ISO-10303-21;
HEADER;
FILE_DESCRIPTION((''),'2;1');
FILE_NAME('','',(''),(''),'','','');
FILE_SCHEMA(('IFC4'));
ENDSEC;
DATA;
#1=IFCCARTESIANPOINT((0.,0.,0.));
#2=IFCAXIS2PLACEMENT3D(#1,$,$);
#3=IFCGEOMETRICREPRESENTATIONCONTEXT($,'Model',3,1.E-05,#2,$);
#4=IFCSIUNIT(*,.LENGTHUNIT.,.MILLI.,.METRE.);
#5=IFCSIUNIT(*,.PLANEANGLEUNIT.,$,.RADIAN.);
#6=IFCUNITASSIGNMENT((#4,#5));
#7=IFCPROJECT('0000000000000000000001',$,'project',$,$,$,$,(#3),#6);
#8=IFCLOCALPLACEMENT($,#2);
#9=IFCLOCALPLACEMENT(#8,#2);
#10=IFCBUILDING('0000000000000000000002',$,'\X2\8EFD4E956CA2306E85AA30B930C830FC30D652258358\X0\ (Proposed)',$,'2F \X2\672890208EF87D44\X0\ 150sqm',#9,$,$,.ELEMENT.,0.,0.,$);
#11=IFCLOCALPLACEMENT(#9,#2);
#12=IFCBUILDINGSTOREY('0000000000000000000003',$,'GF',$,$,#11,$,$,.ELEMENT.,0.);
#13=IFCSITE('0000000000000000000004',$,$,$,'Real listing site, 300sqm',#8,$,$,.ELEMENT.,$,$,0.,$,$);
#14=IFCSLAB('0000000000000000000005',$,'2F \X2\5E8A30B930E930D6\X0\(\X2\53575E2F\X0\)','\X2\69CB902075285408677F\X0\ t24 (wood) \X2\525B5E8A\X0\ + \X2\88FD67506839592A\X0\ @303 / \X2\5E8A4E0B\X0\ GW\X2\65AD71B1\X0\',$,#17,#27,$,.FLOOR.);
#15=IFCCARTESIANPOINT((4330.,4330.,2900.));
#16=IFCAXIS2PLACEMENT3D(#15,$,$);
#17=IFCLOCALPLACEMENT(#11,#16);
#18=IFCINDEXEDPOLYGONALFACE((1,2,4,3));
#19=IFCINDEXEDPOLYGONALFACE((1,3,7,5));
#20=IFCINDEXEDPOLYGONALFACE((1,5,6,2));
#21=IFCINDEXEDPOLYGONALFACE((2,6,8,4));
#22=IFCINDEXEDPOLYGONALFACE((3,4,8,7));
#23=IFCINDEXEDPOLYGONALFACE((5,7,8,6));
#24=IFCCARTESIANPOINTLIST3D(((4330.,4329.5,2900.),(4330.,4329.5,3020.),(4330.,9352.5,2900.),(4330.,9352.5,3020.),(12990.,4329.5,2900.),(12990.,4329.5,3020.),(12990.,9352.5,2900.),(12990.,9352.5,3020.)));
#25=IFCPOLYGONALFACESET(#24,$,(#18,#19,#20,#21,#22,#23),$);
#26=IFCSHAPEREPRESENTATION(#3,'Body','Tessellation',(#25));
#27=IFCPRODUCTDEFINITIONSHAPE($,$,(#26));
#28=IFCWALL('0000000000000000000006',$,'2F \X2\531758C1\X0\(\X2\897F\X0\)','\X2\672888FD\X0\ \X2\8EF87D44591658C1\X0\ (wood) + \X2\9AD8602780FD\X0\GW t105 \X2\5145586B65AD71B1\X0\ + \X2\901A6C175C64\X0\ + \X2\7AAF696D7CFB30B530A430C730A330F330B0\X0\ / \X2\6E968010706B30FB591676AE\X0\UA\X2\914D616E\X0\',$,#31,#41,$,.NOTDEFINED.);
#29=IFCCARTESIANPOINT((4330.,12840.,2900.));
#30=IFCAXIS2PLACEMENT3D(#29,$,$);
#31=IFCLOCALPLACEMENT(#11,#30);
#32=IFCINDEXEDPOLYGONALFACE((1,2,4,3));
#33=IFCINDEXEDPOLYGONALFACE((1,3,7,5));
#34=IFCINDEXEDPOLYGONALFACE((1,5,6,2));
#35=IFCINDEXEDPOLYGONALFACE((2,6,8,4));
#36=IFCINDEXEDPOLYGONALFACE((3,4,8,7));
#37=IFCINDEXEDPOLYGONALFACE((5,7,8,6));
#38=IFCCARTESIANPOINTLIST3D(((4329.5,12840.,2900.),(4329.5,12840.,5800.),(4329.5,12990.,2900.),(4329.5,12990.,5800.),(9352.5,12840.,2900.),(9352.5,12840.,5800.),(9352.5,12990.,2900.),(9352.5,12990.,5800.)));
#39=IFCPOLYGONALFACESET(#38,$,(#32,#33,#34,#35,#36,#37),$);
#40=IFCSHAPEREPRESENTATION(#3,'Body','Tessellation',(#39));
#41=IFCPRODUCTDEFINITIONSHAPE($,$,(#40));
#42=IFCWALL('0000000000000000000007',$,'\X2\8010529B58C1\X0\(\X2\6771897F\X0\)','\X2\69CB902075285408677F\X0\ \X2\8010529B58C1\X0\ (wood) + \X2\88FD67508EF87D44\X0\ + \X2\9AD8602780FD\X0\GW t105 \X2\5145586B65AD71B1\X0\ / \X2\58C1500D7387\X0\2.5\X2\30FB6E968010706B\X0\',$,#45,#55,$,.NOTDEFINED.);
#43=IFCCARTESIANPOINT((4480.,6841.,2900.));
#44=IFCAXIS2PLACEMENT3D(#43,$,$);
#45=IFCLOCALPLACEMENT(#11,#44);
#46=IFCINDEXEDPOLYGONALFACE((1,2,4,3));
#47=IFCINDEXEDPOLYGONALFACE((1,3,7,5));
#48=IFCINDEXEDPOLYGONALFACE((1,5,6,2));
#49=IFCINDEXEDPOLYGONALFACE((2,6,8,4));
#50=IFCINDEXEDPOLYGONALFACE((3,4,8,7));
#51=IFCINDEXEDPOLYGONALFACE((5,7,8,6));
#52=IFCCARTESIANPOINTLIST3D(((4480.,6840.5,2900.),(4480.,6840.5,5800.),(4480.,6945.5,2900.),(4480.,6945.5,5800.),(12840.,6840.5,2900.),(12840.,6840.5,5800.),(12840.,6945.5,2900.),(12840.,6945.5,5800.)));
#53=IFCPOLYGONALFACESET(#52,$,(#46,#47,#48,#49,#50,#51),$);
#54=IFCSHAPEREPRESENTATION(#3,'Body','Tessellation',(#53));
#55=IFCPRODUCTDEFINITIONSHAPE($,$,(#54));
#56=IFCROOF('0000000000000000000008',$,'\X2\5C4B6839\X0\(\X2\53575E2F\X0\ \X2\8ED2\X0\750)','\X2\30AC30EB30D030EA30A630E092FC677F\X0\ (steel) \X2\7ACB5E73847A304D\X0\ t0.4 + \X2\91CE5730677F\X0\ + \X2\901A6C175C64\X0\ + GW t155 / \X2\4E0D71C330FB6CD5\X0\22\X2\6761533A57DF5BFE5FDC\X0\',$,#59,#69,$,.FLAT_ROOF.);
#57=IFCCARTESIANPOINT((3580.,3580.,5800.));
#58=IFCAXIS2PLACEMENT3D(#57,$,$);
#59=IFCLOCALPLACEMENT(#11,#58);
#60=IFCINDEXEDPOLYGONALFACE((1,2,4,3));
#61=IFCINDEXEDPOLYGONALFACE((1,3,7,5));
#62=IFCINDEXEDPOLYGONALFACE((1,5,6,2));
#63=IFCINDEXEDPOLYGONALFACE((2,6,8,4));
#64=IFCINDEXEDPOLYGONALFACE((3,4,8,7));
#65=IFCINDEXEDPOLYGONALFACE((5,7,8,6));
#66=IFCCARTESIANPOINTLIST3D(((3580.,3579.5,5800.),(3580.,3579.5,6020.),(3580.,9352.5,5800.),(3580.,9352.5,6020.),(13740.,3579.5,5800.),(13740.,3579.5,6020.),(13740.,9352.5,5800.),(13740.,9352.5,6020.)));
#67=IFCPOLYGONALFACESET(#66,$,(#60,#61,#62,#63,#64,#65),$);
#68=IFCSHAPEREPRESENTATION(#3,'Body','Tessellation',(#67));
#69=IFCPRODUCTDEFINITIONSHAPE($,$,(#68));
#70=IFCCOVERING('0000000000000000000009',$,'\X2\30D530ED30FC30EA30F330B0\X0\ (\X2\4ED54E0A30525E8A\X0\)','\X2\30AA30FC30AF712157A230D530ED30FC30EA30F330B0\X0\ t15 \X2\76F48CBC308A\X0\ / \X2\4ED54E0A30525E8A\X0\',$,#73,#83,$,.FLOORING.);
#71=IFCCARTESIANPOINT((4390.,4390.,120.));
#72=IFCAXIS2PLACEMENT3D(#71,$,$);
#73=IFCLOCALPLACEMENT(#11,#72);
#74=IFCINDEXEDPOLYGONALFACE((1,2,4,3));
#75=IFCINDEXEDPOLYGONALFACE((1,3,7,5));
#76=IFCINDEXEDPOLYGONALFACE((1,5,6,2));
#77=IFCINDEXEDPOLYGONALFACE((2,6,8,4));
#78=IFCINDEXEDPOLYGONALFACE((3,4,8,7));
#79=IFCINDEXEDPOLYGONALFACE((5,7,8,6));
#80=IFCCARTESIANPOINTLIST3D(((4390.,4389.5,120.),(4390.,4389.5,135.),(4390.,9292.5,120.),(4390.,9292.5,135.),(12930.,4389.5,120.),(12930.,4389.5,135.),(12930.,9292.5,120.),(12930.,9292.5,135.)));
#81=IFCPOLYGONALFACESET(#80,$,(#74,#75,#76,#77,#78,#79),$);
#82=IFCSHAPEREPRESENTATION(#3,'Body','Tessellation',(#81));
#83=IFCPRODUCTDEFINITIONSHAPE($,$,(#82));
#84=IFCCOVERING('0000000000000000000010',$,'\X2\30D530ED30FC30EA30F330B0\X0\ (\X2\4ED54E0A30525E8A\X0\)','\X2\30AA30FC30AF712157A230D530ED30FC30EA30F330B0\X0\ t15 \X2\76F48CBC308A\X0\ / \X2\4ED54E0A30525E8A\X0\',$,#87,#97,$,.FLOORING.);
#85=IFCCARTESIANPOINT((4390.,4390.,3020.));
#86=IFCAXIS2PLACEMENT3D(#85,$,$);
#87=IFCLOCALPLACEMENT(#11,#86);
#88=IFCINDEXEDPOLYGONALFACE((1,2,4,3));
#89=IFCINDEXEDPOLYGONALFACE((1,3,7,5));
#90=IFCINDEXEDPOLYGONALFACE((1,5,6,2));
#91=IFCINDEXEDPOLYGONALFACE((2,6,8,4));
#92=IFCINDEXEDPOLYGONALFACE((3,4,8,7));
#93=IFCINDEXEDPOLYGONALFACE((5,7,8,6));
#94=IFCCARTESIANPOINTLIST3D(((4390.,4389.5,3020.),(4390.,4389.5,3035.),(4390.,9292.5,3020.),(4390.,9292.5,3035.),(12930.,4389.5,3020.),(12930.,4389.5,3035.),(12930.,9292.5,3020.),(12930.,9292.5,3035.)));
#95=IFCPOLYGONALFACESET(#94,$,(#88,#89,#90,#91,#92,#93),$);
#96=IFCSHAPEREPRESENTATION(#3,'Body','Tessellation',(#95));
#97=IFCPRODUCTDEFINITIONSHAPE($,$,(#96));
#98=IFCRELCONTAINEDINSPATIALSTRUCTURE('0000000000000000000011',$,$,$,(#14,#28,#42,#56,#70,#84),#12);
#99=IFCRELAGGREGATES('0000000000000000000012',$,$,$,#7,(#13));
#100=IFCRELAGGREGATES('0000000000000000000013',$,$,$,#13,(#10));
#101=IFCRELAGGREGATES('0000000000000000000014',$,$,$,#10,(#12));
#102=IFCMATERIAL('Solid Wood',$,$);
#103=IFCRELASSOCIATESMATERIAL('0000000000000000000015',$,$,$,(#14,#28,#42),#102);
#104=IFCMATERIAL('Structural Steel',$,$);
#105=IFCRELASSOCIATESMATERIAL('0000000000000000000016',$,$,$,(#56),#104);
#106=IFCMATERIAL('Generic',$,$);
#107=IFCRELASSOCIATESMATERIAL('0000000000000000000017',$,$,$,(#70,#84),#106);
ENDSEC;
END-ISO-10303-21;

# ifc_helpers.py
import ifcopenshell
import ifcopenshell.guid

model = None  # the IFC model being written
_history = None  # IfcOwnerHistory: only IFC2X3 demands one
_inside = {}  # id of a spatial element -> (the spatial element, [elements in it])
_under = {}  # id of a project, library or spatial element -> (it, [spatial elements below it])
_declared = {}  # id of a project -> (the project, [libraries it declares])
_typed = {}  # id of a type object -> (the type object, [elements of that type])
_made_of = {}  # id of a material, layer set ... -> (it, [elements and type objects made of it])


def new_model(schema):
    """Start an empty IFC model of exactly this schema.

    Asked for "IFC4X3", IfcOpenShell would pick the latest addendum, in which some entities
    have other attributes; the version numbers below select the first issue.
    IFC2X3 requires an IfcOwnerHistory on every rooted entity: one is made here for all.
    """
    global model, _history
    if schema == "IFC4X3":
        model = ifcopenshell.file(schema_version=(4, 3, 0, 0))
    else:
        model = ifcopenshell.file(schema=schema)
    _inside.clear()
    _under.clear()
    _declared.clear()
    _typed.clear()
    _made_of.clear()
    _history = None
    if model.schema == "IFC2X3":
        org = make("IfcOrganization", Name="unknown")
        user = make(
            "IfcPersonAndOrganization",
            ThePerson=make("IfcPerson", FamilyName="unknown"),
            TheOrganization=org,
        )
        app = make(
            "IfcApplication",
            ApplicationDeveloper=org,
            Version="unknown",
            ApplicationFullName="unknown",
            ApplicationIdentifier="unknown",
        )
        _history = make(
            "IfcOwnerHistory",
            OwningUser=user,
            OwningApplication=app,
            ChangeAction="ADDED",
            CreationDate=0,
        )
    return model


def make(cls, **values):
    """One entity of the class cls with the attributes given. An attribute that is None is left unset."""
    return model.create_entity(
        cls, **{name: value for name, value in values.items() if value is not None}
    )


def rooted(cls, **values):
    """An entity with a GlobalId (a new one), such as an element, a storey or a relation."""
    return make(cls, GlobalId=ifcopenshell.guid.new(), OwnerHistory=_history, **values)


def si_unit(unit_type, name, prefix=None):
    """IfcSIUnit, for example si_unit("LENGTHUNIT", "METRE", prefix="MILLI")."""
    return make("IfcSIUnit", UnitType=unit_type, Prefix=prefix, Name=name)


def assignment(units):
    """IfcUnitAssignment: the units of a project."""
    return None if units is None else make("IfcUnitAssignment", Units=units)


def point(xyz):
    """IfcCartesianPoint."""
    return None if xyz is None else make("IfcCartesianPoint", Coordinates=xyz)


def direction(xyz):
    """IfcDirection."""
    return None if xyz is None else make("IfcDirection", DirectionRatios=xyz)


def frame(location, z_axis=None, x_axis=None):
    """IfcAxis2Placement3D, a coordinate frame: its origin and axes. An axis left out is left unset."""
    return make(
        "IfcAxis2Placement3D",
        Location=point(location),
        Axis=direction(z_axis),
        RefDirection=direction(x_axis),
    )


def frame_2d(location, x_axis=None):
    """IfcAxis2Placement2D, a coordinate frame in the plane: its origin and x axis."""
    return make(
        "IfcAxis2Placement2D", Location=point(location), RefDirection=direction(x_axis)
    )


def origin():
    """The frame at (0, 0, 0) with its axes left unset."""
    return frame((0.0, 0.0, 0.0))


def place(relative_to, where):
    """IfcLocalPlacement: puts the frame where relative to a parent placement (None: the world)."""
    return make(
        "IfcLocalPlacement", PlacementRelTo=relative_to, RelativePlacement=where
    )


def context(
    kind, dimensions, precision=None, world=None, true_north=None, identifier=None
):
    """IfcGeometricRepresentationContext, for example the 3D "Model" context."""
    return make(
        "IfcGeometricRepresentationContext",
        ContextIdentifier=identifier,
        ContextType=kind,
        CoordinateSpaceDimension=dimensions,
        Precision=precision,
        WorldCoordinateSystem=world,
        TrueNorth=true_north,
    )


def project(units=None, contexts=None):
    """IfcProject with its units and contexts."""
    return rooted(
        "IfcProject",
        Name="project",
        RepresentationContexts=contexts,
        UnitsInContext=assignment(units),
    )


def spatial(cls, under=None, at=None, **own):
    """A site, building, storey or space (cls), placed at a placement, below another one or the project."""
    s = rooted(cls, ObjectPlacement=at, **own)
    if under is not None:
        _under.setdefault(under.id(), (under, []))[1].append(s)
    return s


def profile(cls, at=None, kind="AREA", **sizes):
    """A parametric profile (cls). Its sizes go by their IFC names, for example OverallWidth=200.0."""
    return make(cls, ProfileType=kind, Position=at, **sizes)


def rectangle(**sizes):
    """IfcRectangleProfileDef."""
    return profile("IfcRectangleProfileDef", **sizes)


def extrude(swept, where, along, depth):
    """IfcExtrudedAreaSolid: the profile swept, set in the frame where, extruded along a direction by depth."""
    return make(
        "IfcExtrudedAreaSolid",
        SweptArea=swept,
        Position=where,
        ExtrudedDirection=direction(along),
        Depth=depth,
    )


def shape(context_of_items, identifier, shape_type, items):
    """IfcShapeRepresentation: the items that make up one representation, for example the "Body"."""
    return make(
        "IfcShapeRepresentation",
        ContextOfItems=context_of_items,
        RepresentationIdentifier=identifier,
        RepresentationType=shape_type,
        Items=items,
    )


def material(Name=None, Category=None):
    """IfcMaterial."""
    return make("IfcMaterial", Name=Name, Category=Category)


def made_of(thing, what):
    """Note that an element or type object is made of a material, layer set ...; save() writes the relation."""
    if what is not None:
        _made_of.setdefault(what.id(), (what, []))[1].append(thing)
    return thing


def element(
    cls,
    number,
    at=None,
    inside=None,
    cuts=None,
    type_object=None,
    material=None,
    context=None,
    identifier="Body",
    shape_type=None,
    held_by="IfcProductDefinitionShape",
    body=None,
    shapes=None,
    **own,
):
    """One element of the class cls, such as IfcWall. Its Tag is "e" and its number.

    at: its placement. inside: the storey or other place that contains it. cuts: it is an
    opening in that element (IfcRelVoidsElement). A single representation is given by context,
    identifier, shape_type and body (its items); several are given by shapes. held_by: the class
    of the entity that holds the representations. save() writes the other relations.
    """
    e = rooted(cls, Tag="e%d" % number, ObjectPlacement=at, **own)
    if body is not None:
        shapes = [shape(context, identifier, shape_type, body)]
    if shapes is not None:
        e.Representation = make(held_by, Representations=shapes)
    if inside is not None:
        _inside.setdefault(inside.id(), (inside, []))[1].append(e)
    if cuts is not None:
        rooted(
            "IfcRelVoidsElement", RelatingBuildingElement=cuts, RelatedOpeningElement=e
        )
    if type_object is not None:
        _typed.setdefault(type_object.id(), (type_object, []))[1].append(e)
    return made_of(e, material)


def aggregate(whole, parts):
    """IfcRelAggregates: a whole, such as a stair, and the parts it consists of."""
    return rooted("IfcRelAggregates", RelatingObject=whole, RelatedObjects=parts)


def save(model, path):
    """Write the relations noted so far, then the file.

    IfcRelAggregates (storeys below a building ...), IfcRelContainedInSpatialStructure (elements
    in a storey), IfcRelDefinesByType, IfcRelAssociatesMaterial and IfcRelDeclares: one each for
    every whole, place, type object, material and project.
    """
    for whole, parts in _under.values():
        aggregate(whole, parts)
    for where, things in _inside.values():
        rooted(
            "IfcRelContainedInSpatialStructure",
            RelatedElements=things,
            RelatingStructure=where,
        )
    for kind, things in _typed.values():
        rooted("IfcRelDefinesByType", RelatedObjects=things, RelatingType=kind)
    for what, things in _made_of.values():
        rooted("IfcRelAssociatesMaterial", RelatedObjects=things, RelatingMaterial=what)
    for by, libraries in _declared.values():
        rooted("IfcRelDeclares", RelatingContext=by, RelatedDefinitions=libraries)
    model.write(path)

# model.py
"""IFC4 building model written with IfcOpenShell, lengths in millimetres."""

from ifc_helpers import new_model, si_unit, frame, frame_2d, origin, place, context, project, spatial, rectangle, extrude, material, element, save


model = new_model("IFC4")

# Units and contexts
model_context = context("Model", 3, precision=1e-05, world=origin())
ifc_project = project(units=[si_unit("LENGTHUNIT", "METRE", prefix="MILLI"), si_unit("PLANEANGLEUNIT", "RADIAN")], contexts=[model_context])

# Site, building, storey
site_placement = place(None, origin())
site = spatial("IfcSite", under=ifc_project, at=site_placement, ObjectType="Real listing site, 300sqm", CompositionType="ELEMENT", RefElevation=0.0)
building_placement = place(site_placement, origin())
building = spatial("IfcBuilding", under=site, at=building_placement, Name="軽井沢の薪ストーブ別荘 (Proposed)", ObjectType="2F 木造軸組 150sqm", CompositionType="ELEMENT", ElevationOfRefHeight=0.0, ElevationOfTerrain=0.0)
storey_placement = place(building_placement, origin())
storey = spatial("IfcBuildingStorey", under=building, at=storey_placement, Name="GF", CompositionType="ELEMENT", Elevation=0.0)

# Slab
ifc_material_1 = material(Name="Solid Wood")
slab_1_placement = place(storey_placement, frame((4330.0, 4330.0, 2900.0)))
element("IfcSlab", 1, at=slab_1_placement, inside=storey, material=ifc_material_1, Name="2F 床スラブ(南帯)", Description="構造用合板 t24 (wood) 剛床 + 製材根太 @303 / 床下 GW断熱", PredefinedType="FLOOR", context=model_context, shape_type="SweptSolid", body=[
    extrude(rectangle(XDim=8660.0, YDim=5023.0, at=frame_2d((4330.0, 2511.0))), frame((4330.0, 4330.0, 2900.0)), (0.0, 0.0, 1.0), 120.0),
])

# Walls
wall_1_placement = place(storey_placement, frame((4330.0, 12840.0, 2900.0)))
element("IfcWall", 2, at=wall_1_placement, inside=storey, material=ifc_material_1, Name="2F 北壁(西)", Description="木製 軸組外壁 (wood) + 高性能GW t105 充填断熱 + 通気層 + 窯業系サイディング / 準耐火・外皮UA配慮", PredefinedType="NOTDEFINED", context=model_context, shape_type="SweptSolid", body=[
    extrude(rectangle(XDim=5023.0, YDim=150.0, at=frame_2d((2511.0, 75.0))), frame((4330.0, 12840.0, 2900.0)), (0.0, 0.0, 1.0), 2900.0),
])
wall_2_placement = place(storey_placement, frame((4480.0, 6841.0, 2900.0)))
element("IfcWall", 3, at=wall_2_placement, inside=storey, material=ifc_material_1, Name="耐力壁(東西)", Description="構造用合板 耐力壁 (wood) + 製材軸組 + 高性能GW t105 充填断熱 / 壁倍率2.5・準耐火", PredefinedType="NOTDEFINED", context=model_context, shape_type="SweptSolid", body=[
    extrude(rectangle(XDim=8360.0, YDim=105.0, at=frame_2d((4180.0, 52.0))), frame((4480.0, 6841.0, 2900.0)), (0.0, 0.0, 1.0), 2900.0),
])

# Roof
ifc_material_2 = material(Name="Structural Steel")
roof_1_placement = place(storey_placement, frame((3580.0, 3580.0, 5800.0)))
element("IfcRoof", 4, at=roof_1_placement, inside=storey, material=ifc_material_2, Name="屋根(南帯 軒750)", Description="ガルバリウム鋼板 (steel) 立平葺き t0.4 + 野地板 + 通気層 + GW t155 / 不燃・法22条区域対応", PredefinedType="FLAT_ROOF", context=model_context, shape_type="SweptSolid", body=[
    extrude(rectangle(XDim=10160.0, YDim=5773.0, at=frame_2d((5080.0, 2886.0))), frame((3580.0, 3580.0, 5800.0)), (0.0, 0.0, 1.0), 220.0),
])

# Coverings
ifc_material_3 = material(Name="Generic")
covering_1_placement = place(storey_placement, frame((4390.0, 4390.0, 120.0)))
element("IfcCovering", 5, at=covering_1_placement, inside=storey, material=ifc_material_3, Name="フローリング (仕上げ床)", Description="オーク無垢フローリング t15 直貼り / 仕上げ床", PredefinedType="FLOORING", context=model_context, shape_type="SweptSolid", body=[
    extrude(rectangle(XDim=8540.0, YDim=4903.0, at=frame_2d((4270.0, 2451.0))), frame((4390.0, 4390.0, 120.0)), (0.0, 0.0, 1.0), 15.0),
])
covering_2_placement = place(storey_placement, frame((4390.0, 4390.0, 3020.0)))
element("IfcCovering", 6, at=covering_2_placement, inside=storey, material=ifc_material_3, Name="フローリング (仕上げ床)", Description="オーク無垢フローリング t15 直貼り / 仕上げ床", PredefinedType="FLOORING", context=model_context, shape_type="SweptSolid", body=[
    extrude(rectangle(XDim=8540.0, YDim=4903.0, at=frame_2d((4270.0, 2451.0))), frame((4390.0, 4390.0, 3020.0)), (0.0, 0.0, 1.0), 15.0),
])

save(model, "model.ifc")
